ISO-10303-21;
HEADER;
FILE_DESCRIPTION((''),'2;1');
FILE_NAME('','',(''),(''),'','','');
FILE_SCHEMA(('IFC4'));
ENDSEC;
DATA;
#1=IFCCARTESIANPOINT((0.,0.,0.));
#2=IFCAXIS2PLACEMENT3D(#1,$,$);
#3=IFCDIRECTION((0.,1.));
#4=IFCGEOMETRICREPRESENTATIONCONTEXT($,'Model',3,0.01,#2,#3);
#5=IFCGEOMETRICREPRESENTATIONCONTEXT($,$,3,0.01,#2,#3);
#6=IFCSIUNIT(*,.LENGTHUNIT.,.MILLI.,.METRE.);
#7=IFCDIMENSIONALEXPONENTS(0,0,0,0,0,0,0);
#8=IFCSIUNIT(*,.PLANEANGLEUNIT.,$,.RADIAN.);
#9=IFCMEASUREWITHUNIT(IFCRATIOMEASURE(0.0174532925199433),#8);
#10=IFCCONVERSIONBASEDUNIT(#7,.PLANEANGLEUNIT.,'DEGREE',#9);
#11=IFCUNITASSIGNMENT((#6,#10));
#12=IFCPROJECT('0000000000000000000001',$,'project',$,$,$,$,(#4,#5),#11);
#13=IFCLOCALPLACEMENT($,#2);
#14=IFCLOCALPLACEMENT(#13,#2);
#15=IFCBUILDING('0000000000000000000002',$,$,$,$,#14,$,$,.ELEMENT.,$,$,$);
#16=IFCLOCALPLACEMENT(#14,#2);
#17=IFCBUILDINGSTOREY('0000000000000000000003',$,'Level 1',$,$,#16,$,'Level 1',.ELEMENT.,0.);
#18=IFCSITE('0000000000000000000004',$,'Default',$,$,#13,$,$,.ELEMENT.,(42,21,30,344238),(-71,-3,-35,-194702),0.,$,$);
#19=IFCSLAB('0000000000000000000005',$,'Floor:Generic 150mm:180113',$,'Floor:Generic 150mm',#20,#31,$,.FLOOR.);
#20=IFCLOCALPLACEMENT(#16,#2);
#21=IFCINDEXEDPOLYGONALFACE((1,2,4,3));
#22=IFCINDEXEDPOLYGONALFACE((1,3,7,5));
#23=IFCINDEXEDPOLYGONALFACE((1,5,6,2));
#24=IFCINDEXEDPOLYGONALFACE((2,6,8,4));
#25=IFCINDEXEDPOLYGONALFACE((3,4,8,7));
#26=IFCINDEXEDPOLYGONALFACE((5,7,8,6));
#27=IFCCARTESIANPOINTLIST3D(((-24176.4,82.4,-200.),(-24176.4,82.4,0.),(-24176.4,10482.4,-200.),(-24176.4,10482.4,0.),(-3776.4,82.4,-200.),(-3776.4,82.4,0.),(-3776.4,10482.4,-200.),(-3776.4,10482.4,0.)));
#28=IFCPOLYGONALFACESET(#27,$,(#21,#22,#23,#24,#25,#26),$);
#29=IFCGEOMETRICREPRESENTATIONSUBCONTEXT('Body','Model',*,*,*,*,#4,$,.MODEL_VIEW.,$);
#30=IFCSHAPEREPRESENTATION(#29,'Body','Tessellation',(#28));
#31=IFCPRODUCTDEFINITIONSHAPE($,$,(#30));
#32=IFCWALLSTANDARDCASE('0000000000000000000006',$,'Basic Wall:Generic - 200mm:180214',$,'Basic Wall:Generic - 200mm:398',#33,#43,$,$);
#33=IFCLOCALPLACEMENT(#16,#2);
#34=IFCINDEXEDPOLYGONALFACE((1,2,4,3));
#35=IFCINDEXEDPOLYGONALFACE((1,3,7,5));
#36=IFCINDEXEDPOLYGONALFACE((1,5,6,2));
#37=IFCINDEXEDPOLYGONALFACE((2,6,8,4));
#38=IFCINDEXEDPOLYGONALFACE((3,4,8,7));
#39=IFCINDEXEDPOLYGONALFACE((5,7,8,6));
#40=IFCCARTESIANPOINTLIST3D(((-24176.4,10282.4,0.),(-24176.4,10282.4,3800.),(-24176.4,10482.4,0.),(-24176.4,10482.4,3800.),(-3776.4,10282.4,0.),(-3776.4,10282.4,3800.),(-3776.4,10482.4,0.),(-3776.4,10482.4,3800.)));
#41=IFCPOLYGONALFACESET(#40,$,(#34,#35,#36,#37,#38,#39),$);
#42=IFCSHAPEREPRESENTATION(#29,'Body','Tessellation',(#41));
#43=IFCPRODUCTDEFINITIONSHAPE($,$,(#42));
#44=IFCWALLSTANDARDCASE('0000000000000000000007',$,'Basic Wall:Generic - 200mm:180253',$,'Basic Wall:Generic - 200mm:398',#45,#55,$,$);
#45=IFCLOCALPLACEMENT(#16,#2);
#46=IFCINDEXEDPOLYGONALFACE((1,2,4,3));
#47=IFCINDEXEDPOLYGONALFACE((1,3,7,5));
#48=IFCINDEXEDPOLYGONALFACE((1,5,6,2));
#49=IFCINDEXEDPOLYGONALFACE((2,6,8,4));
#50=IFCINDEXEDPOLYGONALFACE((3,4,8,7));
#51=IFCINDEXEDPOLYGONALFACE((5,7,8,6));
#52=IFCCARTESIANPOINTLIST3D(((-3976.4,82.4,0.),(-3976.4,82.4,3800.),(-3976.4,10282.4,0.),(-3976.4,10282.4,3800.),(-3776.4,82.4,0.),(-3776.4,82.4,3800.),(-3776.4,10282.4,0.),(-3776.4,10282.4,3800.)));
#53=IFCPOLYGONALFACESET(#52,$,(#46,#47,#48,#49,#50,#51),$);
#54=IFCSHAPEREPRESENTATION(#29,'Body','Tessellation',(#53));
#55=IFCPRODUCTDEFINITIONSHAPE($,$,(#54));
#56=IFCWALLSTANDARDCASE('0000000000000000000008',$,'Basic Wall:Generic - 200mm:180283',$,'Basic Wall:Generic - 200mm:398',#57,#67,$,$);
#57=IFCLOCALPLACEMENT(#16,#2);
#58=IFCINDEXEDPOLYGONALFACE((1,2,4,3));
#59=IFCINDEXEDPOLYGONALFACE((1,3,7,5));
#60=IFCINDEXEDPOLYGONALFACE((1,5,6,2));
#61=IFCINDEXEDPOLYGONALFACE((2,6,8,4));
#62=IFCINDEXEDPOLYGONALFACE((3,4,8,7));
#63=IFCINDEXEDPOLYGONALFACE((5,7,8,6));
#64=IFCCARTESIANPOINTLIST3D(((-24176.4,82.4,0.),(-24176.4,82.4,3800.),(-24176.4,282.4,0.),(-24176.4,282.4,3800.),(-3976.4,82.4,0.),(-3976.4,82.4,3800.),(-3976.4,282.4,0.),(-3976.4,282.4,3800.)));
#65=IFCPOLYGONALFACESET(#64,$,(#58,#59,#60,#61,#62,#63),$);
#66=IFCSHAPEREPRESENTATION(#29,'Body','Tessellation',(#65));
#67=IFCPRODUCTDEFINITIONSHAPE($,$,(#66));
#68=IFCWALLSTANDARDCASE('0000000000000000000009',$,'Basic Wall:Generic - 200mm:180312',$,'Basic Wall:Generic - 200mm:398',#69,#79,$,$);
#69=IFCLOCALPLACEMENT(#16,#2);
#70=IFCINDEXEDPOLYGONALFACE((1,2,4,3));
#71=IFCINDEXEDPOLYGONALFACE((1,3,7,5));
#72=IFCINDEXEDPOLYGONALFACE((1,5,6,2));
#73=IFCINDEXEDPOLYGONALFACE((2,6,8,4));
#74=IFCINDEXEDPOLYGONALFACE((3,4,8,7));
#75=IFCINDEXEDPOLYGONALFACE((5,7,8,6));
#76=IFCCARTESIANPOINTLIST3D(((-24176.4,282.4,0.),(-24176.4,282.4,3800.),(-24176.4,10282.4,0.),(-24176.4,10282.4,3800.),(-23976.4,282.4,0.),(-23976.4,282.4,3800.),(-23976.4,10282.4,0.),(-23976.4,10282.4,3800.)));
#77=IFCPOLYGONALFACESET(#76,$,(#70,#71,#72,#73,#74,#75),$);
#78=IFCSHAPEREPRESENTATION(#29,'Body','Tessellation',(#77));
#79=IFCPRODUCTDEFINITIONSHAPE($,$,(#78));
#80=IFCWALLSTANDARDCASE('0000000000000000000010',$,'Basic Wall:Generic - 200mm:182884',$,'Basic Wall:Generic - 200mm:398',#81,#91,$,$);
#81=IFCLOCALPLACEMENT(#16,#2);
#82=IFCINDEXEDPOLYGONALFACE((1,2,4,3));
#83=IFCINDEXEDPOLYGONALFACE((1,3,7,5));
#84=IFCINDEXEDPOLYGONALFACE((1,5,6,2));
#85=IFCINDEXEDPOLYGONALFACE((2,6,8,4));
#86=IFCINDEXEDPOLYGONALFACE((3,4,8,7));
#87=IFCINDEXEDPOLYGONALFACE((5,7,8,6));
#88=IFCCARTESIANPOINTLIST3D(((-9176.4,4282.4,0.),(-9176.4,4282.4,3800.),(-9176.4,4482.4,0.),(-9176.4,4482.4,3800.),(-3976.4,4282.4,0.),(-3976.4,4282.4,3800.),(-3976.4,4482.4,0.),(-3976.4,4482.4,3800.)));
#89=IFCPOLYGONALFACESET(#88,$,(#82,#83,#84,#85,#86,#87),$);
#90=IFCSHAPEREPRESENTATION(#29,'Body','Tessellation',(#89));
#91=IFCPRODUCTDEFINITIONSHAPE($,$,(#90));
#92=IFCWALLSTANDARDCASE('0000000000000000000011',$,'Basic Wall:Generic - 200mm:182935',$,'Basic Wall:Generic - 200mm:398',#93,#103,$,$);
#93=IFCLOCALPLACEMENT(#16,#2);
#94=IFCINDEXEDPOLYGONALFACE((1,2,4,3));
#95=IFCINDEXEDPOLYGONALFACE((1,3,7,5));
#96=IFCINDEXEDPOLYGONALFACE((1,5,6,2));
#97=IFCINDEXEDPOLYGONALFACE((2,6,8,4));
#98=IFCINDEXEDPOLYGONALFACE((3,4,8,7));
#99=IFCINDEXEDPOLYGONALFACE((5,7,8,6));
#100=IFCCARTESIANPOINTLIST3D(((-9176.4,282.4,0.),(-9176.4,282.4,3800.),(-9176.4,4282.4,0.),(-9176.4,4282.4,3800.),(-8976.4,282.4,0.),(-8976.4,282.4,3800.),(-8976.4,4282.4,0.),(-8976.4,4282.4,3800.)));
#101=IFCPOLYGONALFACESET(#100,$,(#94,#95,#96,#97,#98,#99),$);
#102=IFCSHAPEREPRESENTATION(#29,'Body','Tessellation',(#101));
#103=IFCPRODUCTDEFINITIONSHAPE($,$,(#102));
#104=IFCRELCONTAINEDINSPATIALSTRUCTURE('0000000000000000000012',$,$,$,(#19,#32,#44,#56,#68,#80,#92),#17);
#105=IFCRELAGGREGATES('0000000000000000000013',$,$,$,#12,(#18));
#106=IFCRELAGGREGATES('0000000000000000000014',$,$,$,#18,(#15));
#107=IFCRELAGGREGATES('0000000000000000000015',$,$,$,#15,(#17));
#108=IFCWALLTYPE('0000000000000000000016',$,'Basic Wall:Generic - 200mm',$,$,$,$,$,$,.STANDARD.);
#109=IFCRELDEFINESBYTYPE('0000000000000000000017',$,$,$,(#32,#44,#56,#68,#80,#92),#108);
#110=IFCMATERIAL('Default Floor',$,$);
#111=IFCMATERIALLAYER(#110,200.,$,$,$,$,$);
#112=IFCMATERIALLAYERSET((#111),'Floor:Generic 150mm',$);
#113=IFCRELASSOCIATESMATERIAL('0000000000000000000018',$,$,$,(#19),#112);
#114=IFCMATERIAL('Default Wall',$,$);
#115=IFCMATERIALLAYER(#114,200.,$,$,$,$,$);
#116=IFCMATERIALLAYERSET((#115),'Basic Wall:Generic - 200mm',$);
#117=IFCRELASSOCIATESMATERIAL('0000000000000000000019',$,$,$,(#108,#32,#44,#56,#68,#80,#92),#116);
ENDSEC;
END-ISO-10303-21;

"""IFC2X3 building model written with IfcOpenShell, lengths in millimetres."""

from ifc_helpers import new_model, entity, si_unit, converted_unit, direction, frame, frame_2d, origin, origin_2d_with_axis, place, context, subcontext, project, spatial, rectangle, extrude, material, layer, layer_set, layer_usage, type_object, element, save


model = new_model("IFC2X3")

# Units and contexts
model_context = context("Model", 3, precision=0.01, world=origin(), true_north=direction((0.0, 1.0)))
context_of_model = context(None, 3, precision=0.01, world=origin(), true_north=direction((0.0, 1.0)))
body_context = subcontext(model_context, "Body", "Model", "MODEL_VIEW")
ifc_project = project(units=[si_unit("LENGTHUNIT", "METRE", prefix="MILLI"), converted_unit("PLANEANGLEUNIT", "DEGREE", entity("IfcRatioMeasure", 0.0174532925199433), si_unit("PLANEANGLEUNIT", "RADIAN"), dimensions=[0, 0, 0, 0, 0, 0, 0])], contexts=[model_context, context_of_model])

# Site, building, storey
site_placement = place(None, origin())
site = spatial("IfcSite", under=ifc_project, at=site_placement, Name="Default", CompositionType="ELEMENT", RefLatitude=(42, 21, 30, 344238), RefLongitude=(-71, -3, -35, -194702), RefElevation=0.0)
building_placement = place(site_placement, origin())
building = spatial("IfcBuilding", under=site, at=building_placement, CompositionType="ELEMENT")
storey_placement = place(building_placement, origin())
storey = spatial("IfcBuildingStorey", under=building, at=storey_placement, Name="Level 1", LongName="Level 1", CompositionType="ELEMENT", Elevation=0.0)

# Slab
ifc_material_1 = material(Name="Default Floor")
ifc_layer_1 = layer(ifc_material_1, 200.0)
ifc_layer_set_1 = layer_set([ifc_layer_1], Name="Floor:Generic 150mm")
ifc_layer_usage_1 = layer_usage(ifc_layer_set_1, "AXIS3", "POSITIVE", 0.0)
slab_placement = place(storey_placement, origin())
element("IfcSlab", 1, at=slab_placement, inside=storey, material=ifc_layer_usage_1, Name="Floor:Generic 150mm:180113", ObjectType="Floor:Generic 150mm", PredefinedType="FLOOR", context=body_context, shape_type="SweptSolid", body=[
    extrude(rectangle(XDim=10400.0, YDim=20400.0, at=origin_2d_with_axis()), frame((-13976.4, 5282.4, 0.0), z_axis=(0.0, 0.0, -1.0), x_axis=(0.0, 1.0, 0.0)), (0.0, 0.0, 1.0), 200.0),
])

# Walls
ifc_material_2 = material(Name="Default Wall")
ifc_layer_2 = layer(ifc_material_2, 200.0)
ifc_layer_set_2 = layer_set([ifc_layer_2], Name="Basic Wall:Generic - 200mm")
ifc_layer_usage_2 = layer_usage(ifc_layer_set_2, "AXIS2", "NEGATIVE", 100.0)
wall_type = type_object("IfcWallType", Name="Basic Wall:Generic - 200mm", PredefinedType="STANDARD", material=ifc_layer_set_2)
wall_1_placement = place(storey_placement, frame((-24176.4, 10382.4, 0.0)))
element("IfcWallStandardCase", 2, at=wall_1_placement, inside=storey, type_object=wall_type, material=ifc_layer_usage_2, Name="Basic Wall:Generic - 200mm:180214", ObjectType="Basic Wall:Generic - 200mm:398", context=body_context, shape_type="SweptSolid", body=[
    extrude(rectangle(XDim=20400.0, YDim=200.0, at=frame_2d((10200.0, 0.0), x_axis=(-1.0, 0.0))), origin(), (0.0, 0.0, 1.0), 3800.0),
])
ifc_layer_usage_3 = layer_usage(ifc_layer_set_2, "AXIS2", "NEGATIVE", 100.0)
wall_2_placement = place(storey_placement, frame((-3876.4, 10282.4, 0.0), z_axis=(0.0, 0.0, 1.0), x_axis=(0.0, -1.0, 0.0)))
element("IfcWallStandardCase", 3, at=wall_2_placement, inside=storey, type_object=wall_type, material=ifc_layer_usage_3, Name="Basic Wall:Generic - 200mm:180253", ObjectType="Basic Wall:Generic - 200mm:398", context=body_context, shape_type="SweptSolid", body=[
    extrude(rectangle(XDim=10200.0, YDim=200.0, at=frame_2d((5100.0, 0.0), x_axis=(-1.0, 0.0))), origin(), (0.0, 0.0, 1.0), 3800.0),
])
ifc_layer_usage_4 = layer_usage(ifc_layer_set_2, "AXIS2", "NEGATIVE", 100.0)
wall_3_placement = place(storey_placement, frame((-3976.4, 182.4, 0.0), z_axis=(0.0, 0.0, 1.0), x_axis=(-1.0, 0.0, 0.0)))
element("IfcWallStandardCase", 4, at=wall_3_placement, inside=storey, type_object=wall_type, material=ifc_layer_usage_4, Name="Basic Wall:Generic - 200mm:180283", ObjectType="Basic Wall:Generic - 200mm:398", context=body_context, shape_type="SweptSolid", body=[
    extrude(rectangle(XDim=20200.0, YDim=200.0, at=frame_2d((10100.0, 0.0), x_axis=(-1.0, 0.0))), origin(), (0.0, 0.0, 1.0), 3800.0),
])
ifc_layer_usage_5 = layer_usage(ifc_layer_set_2, "AXIS2", "NEGATIVE", 100.0)
wall_4_placement = place(storey_placement, frame((-24076.4, 282.4, 0.0), z_axis=(0.0, 0.0, 1.0), x_axis=(0.0, 1.0, 0.0)))
element("IfcWallStandardCase", 5, at=wall_4_placement, inside=storey, type_object=wall_type, material=ifc_layer_usage_5, Name="Basic Wall:Generic - 200mm:180312", ObjectType="Basic Wall:Generic - 200mm:398", context=body_context, shape_type="SweptSolid", body=[
    extrude(rectangle(XDim=10000.0, YDim=200.0, at=frame_2d((5000.0, 0.0), x_axis=(-1.0, 0.0))), origin(), (0.0, 0.0, 1.0), 3800.0),
])
ifc_layer_usage_6 = layer_usage(ifc_layer_set_2, "AXIS2", "NEGATIVE", 100.0)
wall_5_placement = place(storey_placement, frame((-3976.4, 4382.4, 0.0), z_axis=(0.0, 0.0, 1.0), x_axis=(-1.0, 0.0, 0.0)))
element("IfcWallStandardCase", 6, at=wall_5_placement, inside=storey, type_object=wall_type, material=ifc_layer_usage_6, Name="Basic Wall:Generic - 200mm:182884", ObjectType="Basic Wall:Generic - 200mm:398", context=body_context, shape_type="SweptSolid", body=[
    extrude(rectangle(XDim=5200.0, YDim=200.0, at=frame_2d((2600.0, 0.0), x_axis=(-1.0, 0.0))), origin(), (0.0, 0.0, 1.0), 3800.0),
])
ifc_layer_usage_7 = layer_usage(ifc_layer_set_2, "AXIS2", "NEGATIVE", 100.0)
wall_6_placement = place(storey_placement, frame((-9076.4, 4282.4, 0.0), z_axis=(0.0, 0.0, 1.0), x_axis=(0.0, -1.0, 0.0)))
element("IfcWallStandardCase", 7, at=wall_6_placement, inside=storey, type_object=wall_type, material=ifc_layer_usage_7, Name="Basic Wall:Generic - 200mm:182935", ObjectType="Basic Wall:Generic - 200mm:398", context=body_context, shape_type="SweptSolid", body=[
    extrude(rectangle(XDim=4000.0, YDim=200.0, at=frame_2d((2000.0, 0.0), x_axis=(-1.0, 0.0))), origin(), (0.0, 0.0, 1.0), 3800.0),
])

save(model, "model.ifc")
